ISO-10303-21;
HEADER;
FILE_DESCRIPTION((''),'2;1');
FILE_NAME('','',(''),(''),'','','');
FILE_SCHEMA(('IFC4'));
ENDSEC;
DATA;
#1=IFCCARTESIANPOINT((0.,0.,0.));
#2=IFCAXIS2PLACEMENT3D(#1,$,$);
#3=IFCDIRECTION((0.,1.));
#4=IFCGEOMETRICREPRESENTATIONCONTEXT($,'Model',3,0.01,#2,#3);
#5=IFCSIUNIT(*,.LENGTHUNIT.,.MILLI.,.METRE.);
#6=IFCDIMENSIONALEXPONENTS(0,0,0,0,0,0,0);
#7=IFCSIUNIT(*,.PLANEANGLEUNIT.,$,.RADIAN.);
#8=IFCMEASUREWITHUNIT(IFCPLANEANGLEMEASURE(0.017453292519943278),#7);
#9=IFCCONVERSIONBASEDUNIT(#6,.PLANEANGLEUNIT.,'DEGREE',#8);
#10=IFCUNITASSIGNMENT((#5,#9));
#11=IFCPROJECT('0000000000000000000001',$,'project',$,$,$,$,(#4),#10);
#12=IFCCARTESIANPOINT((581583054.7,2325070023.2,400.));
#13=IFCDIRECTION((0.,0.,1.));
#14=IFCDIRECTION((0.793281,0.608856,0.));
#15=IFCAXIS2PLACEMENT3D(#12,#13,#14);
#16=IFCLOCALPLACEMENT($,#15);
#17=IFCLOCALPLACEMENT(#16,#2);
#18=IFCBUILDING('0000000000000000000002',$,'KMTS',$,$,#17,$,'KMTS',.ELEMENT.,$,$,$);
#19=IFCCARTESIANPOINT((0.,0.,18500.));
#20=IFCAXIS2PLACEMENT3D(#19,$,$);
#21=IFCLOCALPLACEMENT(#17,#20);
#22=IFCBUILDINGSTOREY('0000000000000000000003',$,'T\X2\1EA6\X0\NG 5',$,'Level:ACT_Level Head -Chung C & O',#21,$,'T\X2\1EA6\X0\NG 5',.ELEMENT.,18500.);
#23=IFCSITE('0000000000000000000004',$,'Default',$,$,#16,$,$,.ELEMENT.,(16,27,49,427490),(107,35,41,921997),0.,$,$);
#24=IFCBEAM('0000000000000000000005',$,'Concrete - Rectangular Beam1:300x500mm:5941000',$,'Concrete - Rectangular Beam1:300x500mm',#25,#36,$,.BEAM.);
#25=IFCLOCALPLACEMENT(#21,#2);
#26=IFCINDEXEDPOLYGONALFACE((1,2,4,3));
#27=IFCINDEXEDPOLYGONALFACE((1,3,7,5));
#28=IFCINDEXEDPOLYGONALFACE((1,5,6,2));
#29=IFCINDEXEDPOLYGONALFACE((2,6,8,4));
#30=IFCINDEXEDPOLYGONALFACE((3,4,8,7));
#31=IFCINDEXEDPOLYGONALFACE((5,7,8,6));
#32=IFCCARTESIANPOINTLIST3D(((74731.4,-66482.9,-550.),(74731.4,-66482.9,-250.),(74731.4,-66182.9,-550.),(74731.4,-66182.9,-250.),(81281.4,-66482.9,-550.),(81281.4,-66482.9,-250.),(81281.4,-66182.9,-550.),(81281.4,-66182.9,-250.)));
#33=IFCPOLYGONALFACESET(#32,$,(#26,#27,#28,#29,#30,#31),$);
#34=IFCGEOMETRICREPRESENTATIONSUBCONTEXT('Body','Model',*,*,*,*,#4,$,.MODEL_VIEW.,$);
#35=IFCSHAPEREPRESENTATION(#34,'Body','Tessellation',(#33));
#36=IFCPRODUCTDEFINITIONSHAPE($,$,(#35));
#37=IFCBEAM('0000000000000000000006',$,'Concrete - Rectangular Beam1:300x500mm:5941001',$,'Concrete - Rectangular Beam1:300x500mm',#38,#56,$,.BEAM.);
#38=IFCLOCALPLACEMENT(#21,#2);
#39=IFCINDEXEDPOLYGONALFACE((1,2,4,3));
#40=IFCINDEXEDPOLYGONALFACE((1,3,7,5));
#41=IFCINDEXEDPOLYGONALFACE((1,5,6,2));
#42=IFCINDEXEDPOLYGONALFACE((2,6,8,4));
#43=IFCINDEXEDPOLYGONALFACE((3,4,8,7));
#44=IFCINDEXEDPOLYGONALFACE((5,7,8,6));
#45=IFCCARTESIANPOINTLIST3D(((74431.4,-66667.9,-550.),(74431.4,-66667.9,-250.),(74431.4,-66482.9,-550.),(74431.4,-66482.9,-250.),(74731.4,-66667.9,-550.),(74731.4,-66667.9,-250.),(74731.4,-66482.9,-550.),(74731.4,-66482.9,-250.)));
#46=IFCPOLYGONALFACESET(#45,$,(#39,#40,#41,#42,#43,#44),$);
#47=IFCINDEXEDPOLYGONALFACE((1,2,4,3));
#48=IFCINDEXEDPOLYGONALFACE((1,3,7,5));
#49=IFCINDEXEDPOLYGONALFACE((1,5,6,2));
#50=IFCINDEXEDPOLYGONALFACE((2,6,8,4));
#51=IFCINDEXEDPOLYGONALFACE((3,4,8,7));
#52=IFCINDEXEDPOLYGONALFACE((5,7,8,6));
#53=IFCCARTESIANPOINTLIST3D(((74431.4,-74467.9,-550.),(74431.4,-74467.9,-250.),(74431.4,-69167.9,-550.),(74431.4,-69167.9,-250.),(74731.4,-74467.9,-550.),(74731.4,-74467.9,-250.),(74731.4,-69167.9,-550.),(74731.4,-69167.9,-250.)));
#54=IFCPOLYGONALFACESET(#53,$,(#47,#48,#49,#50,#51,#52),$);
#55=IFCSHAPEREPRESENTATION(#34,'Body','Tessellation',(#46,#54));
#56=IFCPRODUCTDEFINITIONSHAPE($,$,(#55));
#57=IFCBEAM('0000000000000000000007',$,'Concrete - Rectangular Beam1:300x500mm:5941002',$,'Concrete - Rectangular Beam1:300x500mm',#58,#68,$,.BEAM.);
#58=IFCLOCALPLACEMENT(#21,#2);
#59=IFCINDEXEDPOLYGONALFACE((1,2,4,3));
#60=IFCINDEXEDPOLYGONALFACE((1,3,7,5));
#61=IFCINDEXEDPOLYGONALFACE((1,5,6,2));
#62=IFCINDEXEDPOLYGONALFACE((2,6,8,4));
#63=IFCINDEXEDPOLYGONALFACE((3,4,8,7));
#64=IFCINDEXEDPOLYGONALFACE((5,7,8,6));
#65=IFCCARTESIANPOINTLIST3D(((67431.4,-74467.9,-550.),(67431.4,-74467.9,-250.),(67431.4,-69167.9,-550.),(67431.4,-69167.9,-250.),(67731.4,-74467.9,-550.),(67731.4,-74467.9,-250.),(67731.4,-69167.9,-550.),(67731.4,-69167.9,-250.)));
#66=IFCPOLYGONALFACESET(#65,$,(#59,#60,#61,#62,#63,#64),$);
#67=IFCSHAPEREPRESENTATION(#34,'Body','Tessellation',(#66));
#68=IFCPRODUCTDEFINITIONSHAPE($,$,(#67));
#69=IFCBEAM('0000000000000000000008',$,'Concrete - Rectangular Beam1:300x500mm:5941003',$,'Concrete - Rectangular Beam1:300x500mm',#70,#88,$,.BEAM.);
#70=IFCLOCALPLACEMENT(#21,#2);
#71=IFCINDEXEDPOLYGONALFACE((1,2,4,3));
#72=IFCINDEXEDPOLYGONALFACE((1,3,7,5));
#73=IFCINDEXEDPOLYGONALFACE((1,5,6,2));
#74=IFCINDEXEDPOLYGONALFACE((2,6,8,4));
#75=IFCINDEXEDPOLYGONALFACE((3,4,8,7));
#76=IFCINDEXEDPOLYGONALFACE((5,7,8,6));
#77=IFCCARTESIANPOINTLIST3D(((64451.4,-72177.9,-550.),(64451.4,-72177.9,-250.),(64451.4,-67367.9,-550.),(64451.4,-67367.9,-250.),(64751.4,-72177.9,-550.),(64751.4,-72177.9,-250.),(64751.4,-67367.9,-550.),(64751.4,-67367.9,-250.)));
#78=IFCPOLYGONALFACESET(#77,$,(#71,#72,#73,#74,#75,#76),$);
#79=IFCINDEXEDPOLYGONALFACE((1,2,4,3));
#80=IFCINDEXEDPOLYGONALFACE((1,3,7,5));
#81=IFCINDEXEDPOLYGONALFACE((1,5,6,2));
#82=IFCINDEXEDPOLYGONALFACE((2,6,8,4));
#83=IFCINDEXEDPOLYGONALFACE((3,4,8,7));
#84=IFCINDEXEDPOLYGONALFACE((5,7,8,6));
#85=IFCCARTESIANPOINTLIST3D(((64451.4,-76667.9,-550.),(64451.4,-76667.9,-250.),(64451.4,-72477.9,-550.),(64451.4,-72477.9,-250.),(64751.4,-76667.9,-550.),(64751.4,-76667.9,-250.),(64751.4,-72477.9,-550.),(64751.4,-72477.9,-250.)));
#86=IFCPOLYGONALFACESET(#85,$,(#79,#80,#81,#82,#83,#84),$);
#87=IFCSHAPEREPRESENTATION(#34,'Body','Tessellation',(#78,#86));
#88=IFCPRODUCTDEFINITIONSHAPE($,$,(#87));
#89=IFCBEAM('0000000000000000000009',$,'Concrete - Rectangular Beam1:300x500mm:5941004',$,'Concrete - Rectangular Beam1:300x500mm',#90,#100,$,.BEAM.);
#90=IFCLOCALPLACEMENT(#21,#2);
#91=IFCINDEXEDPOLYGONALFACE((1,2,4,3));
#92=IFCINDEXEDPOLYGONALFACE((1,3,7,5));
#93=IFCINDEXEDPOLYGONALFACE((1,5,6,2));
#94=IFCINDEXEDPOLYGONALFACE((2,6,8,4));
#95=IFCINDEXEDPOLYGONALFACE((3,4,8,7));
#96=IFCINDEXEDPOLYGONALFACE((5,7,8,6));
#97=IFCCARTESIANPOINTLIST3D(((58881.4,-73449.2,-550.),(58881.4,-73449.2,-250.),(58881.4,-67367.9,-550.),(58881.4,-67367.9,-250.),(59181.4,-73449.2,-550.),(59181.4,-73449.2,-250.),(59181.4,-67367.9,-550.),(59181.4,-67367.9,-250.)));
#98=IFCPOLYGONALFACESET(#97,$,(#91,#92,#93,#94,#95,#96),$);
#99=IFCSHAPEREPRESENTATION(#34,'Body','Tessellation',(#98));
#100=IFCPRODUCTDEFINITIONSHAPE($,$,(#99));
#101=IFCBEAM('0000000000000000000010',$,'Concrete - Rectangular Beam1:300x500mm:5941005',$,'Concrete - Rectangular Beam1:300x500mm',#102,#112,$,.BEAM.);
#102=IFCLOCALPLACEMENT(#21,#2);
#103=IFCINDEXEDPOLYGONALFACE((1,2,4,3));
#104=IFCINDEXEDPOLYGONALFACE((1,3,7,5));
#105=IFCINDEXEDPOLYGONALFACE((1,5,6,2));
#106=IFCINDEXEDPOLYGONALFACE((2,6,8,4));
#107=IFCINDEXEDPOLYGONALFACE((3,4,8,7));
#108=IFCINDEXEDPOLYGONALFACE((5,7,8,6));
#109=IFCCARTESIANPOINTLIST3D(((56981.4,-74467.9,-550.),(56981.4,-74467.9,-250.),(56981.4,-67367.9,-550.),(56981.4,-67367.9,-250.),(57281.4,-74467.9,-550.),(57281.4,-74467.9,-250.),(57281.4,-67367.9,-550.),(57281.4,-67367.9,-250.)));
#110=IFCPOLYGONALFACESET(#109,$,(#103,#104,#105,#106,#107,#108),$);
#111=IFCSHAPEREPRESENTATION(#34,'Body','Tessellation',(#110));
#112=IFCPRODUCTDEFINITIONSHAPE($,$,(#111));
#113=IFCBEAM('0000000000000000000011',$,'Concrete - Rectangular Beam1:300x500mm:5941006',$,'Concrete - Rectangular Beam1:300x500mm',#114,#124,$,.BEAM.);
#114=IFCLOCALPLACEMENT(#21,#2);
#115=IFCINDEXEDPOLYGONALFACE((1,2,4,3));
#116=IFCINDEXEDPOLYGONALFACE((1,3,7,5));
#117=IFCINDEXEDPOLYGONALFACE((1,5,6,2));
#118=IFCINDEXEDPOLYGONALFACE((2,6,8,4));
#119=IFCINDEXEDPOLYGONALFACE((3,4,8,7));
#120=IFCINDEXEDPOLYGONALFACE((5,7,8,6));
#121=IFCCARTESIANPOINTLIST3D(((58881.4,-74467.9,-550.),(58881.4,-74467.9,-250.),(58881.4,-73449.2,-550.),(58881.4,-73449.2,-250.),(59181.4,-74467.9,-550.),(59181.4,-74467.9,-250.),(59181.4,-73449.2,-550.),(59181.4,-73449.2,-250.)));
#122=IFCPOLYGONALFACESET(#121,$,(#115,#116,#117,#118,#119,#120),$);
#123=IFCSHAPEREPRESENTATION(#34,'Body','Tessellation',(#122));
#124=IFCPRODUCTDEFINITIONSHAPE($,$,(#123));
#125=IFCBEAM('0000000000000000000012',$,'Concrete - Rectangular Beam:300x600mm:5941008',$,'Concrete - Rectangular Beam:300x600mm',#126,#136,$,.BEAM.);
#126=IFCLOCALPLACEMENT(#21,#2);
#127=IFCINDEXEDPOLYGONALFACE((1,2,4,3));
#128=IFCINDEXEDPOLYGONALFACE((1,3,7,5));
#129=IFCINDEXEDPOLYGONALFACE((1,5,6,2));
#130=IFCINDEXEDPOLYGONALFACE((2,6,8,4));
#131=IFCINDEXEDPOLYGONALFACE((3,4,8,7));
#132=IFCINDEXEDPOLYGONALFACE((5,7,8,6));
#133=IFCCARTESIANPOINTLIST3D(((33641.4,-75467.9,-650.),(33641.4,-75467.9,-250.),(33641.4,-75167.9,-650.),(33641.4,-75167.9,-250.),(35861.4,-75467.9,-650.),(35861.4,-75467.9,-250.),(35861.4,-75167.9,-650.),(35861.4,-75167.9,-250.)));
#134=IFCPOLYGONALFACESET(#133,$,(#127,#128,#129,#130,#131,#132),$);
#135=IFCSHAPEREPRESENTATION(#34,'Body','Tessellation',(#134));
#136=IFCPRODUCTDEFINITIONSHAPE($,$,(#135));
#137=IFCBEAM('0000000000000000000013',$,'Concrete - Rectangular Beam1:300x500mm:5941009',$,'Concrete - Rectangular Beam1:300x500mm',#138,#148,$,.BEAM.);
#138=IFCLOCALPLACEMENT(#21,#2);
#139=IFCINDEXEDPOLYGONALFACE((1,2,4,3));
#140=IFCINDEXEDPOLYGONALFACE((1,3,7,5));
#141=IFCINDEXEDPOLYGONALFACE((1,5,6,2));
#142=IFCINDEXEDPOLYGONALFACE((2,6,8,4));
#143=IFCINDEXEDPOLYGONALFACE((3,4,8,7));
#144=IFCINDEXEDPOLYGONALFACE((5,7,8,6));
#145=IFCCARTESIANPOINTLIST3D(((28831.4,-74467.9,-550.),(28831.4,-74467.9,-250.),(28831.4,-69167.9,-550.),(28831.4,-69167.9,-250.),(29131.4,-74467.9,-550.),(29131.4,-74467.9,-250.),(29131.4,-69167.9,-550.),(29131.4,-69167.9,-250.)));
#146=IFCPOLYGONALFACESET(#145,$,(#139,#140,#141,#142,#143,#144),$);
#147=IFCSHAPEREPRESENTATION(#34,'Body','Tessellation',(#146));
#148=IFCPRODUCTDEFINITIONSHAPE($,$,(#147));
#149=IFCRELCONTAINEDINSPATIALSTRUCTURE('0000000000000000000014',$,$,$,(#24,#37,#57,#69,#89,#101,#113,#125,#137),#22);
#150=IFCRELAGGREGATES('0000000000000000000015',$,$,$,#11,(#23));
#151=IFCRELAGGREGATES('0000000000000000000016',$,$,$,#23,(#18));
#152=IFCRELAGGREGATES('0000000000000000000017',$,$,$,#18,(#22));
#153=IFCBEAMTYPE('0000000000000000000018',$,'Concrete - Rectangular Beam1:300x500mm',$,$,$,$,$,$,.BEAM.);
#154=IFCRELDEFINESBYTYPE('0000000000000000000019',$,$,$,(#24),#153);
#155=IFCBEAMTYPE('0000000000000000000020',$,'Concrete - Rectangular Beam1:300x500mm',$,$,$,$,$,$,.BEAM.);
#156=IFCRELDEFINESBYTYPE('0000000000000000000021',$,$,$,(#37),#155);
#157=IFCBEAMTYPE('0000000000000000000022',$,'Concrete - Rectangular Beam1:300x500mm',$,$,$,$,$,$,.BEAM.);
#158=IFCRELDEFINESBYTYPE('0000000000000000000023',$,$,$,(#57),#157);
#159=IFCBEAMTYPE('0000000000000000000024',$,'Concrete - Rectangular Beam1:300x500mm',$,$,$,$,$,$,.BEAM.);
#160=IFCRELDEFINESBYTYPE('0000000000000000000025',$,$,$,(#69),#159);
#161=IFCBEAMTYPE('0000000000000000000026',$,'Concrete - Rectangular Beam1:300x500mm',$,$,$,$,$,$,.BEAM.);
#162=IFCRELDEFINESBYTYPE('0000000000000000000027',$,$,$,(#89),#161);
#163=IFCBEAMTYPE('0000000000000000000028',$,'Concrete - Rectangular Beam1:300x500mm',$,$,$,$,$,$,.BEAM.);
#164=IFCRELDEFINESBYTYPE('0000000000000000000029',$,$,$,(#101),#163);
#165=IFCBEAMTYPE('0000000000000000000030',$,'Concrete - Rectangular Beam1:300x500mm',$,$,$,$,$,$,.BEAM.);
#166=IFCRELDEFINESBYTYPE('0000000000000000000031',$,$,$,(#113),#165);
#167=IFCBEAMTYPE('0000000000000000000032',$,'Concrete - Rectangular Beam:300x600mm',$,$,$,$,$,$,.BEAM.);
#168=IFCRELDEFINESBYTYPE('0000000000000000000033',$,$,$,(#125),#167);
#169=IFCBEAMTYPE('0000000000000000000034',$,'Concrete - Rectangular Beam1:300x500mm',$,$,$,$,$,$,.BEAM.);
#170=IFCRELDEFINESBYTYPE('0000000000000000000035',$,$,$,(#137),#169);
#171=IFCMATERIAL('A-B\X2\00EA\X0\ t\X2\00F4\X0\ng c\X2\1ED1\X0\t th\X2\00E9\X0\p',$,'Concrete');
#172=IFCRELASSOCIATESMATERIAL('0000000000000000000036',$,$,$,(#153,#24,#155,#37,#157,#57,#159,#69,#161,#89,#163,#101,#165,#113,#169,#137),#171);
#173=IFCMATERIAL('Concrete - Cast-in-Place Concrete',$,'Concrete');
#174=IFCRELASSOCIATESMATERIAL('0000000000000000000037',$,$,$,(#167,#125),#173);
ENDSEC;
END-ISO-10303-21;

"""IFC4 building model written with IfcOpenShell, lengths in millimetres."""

from ifc_helpers import new_model, entity, si_unit, converted_unit, direction, frame, origin, place, context, subcontext, project, spatial, indexed_curve, outline, extrude, source, transform, mapped, material, type_object, type_shapes, element, save


model = new_model("IFC4")

# Units and contexts
model_context = context("Model", 3, precision=0.01, world=origin(), true_north=direction((0.0, 1.0)))
body_context = subcontext(model_context, "Body", "Model", "MODEL_VIEW")
ifc_project = project(units=[si_unit("LENGTHUNIT", "METRE", prefix="MILLI"), converted_unit("PLANEANGLEUNIT", "DEGREE", entity("IfcPlaneAngleMeasure", 0.017453292519943278), si_unit("PLANEANGLEUNIT", "RADIAN"), dimensions=[0, 0, 0, 0, 0, 0, 0])], contexts=[model_context])

# Site, building, storey
site_placement = place(None, frame((581583054.7, 2325070023.2, 400.0), z_axis=(0.0, 0.0, 1.0), x_axis=(0.793281, 0.608856, 0.0)))
site = spatial("IfcSite", under=ifc_project, at=site_placement, Name="Default", CompositionType="ELEMENT", RefLatitude=(16, 27, 49, 427490), RefLongitude=(107, 35, 41, 921997), RefElevation=0.0)
building_placement = place(site_placement, origin())
building = spatial("IfcBuilding", under=site, at=building_placement, Name="KMTS", LongName="KMTS", CompositionType="ELEMENT")
storey_placement = place(building_placement, frame((0.0, 0.0, 18500.0)))
storey = spatial("IfcBuildingStorey", under=building, at=storey_placement, Name="TẦNG 5", ObjectType="Level:ACT_Level Head -Chung C & O", LongName="TẦNG 5", CompositionType="ELEMENT", Elevation=18500.0)

# Beams
ifc_material_1 = material(Name="A-Bê tông cốt thép", Category="Concrete")
beam_type_1 = type_object("IfcBeamType", Name="Concrete - Rectangular Beam1:300x500mm", PredefinedType="BEAM", material=ifc_material_1)
shared_shape_1 = source(origin(), body_context, "Body", "SweptSolid", [
    extrude(outline(indexed_curve([(-150.0, -150.0), (150.0, -150.0), (150.0, 150.0), (-150.0, 150.0), (-150.0, -150.0)], self_intersect=False)), frame((81281.4, -66332.9, 18100.0), z_axis=(-1.0, 0.0, 0.0), x_axis=(0.0, 0.0, -1.0)), (0.0, 0.0, 1.0), 6550.0),
])
type_shapes(beam_type_1, [shared_shape_1])
beam_1_placement = place(storey_placement, frame((0.0, 0.0, -18500.0)))
element("IfcBeam", 1, at=beam_1_placement, inside=storey, type_object=beam_type_1, material=ifc_material_1, Name="Concrete - Rectangular Beam1:300x500mm:5941000", ObjectType="Concrete - Rectangular Beam1:300x500mm", PredefinedType="BEAM", context=body_context, shape_type="MappedRepresentation", body=[
    mapped(shared_shape_1, transform((0.0, 0.0, 0.0), scale=1.0)),
])
beam_type_2 = type_object("IfcBeamType", Name="Concrete - Rectangular Beam1:300x500mm", PredefinedType="BEAM", material=ifc_material_1)
shared_shape_2 = source(origin(), body_context, "Body", "SweptSolid", [
    extrude(outline(indexed_curve([(-150.0, -150.0), (150.0, -150.0), (150.0, 150.0), (-150.0, 150.0), (-150.0, -150.0)], self_intersect=False)), frame((74581.4, -66482.9, 18100.0), z_axis=(0.0, -1.0, 0.0), x_axis=(-1.0, 0.0, 0.0)), (0.0, 0.0, 1.0), 185.0),
    extrude(outline(indexed_curve([(-150.0, -150.0), (150.0, -150.0), (150.0, 150.0), (-150.0, 150.0), (-150.0, -150.0)], self_intersect=False)), frame((74581.4, -69167.9, 18100.0), z_axis=(0.0, -1.0, 0.0), x_axis=(-1.0, 0.0, 0.0)), (0.0, 0.0, 1.0), 5300.0),
])
type_shapes(beam_type_2, [shared_shape_2])
beam_2_placement = place(storey_placement, frame((0.0, 0.0, -18500.0)))
element("IfcBeam", 2, at=beam_2_placement, inside=storey, type_object=beam_type_2, material=ifc_material_1, Name="Concrete - Rectangular Beam1:300x500mm:5941001", ObjectType="Concrete - Rectangular Beam1:300x500mm", PredefinedType="BEAM", context=body_context, shape_type="MappedRepresentation", body=[
    mapped(shared_shape_2, transform((0.0, 0.0, 0.0), scale=1.0)),
])
beam_type_3 = type_object("IfcBeamType", Name="Concrete - Rectangular Beam1:300x500mm", PredefinedType="BEAM", material=ifc_material_1)
shared_shape_3 = source(origin(), body_context, "Body", "SweptSolid", [
    extrude(outline(indexed_curve([(-150.0, -150.0), (150.0, -150.0), (150.0, 150.0), (-150.0, 150.0), (-150.0, -150.0)], self_intersect=False)), frame((67581.4, -69167.9, 18100.0), z_axis=(0.0, -1.0, 0.0), x_axis=(-1.0, 0.0, 0.0)), (0.0, 0.0, 1.0), 5300.0),
])
type_shapes(beam_type_3, [shared_shape_3])
beam_3_placement = place(storey_placement, frame((0.0, 0.0, -18500.0)))
element("IfcBeam", 3, at=beam_3_placement, inside=storey, type_object=beam_type_3, material=ifc_material_1, Name="Concrete - Rectangular Beam1:300x500mm:5941002", ObjectType="Concrete - Rectangular Beam1:300x500mm", PredefinedType="BEAM", context=body_context, shape_type="MappedRepresentation", body=[
    mapped(shared_shape_3, transform((0.0, 0.0, 0.0), scale=1.0)),
])
beam_type_4 = type_object("IfcBeamType", Name="Concrete - Rectangular Beam1:300x500mm", PredefinedType="BEAM", material=ifc_material_1)
shared_shape_4 = source(origin(), body_context, "Body", "SweptSolid", [
    extrude(outline(indexed_curve([(-150.0, -150.0), (150.0, -150.0), (150.0, 150.0), (-150.0, 150.0), (-150.0, -150.0)], self_intersect=False)), frame((64601.4, -67367.9, 18100.0), z_axis=(0.0, -1.0, 0.0), x_axis=(-1.0, 0.0, 0.0)), (0.0, 0.0, 1.0), 4810.0),
    extrude(outline(indexed_curve([(-150.0, -150.0), (150.0, -150.0), (150.0, 150.0), (-150.0, 150.0), (-150.0, -150.0)], self_intersect=False)), frame((64601.4, -72477.9, 18100.0), z_axis=(0.0, -1.0, 0.0), x_axis=(-1.0, 0.0, 0.0)), (0.0, 0.0, 1.0), 4190.0),
])
type_shapes(beam_type_4, [shared_shape_4])
beam_4_placement = place(storey_placement, frame((0.0, 0.0, -18500.0)))
element("IfcBeam", 4, at=beam_4_placement, inside=storey, type_object=beam_type_4, material=ifc_material_1, Name="Concrete - Rectangular Beam1:300x500mm:5941003", ObjectType="Concrete - Rectangular Beam1:300x500mm", PredefinedType="BEAM", context=body_context, shape_type="MappedRepresentation", body=[
    mapped(shared_shape_4, transform((0.0, 0.0, 0.0), scale=1.0)),
])
beam_type_5 = type_object("IfcBeamType", Name="Concrete - Rectangular Beam1:300x500mm", PredefinedType="BEAM", material=ifc_material_1)
shared_shape_5 = source(origin(), body_context, "Body", "SweptSolid", [
    extrude(outline(indexed_curve([(-150.0, -150.0), (150.0, -150.0), (150.0, 150.0), (-150.0, 150.0), (-150.0, -150.0)], self_intersect=False)), frame((59031.4, -73449.2, 18100.0), z_axis=(0.0, 1.0, 0.0), x_axis=(-1.0, 0.0, 0.0)), (0.0, 0.0, 1.0), 6081.3),
])
type_shapes(beam_type_5, [shared_shape_5])
beam_5_placement = place(storey_placement, frame((0.0, 0.0, -18500.0)))
element("IfcBeam", 5, at=beam_5_placement, inside=storey, type_object=beam_type_5, material=ifc_material_1, Name="Concrete - Rectangular Beam1:300x500mm:5941004", ObjectType="Concrete - Rectangular Beam1:300x500mm", PredefinedType="BEAM", context=body_context, shape_type="MappedRepresentation", body=[
    mapped(shared_shape_5, transform((0.0, 0.0, 0.0), scale=1.0)),
])
beam_type_6 = type_object("IfcBeamType", Name="Concrete - Rectangular Beam1:300x500mm", PredefinedType="BEAM", material=ifc_material_1)
shared_shape_6 = source(origin(), body_context, "Body", "SweptSolid", [
    extrude(outline(indexed_curve([(-150.0, -150.0), (150.0, -150.0), (150.0, 150.0), (-150.0, 150.0), (-150.0, -150.0)], self_intersect=False)), frame((57131.4, -67367.9, 18100.0), z_axis=(0.0, -1.0, 0.0), x_axis=(-1.0, 0.0, 0.0)), (0.0, 0.0, 1.0), 7100.0),
])
type_shapes(beam_type_6, [shared_shape_6])
beam_6_placement = place(storey_placement, frame((0.0, 0.0, -18500.0)))
element("IfcBeam", 6, at=beam_6_placement, inside=storey, type_object=beam_type_6, material=ifc_material_1, Name="Concrete - Rectangular Beam1:300x500mm:5941005", ObjectType="Concrete - Rectangular Beam1:300x500mm", PredefinedType="BEAM", context=body_context, shape_type="MappedRepresentation", body=[
    mapped(shared_shape_6, transform((0.0, 0.0, 0.0), scale=1.0)),
])
beam_type_7 = type_object("IfcBeamType", Name="Concrete - Rectangular Beam1:300x500mm", PredefinedType="BEAM", material=ifc_material_1)
shared_shape_7 = source(origin(), body_context, "Body", "SweptSolid", [
    extrude(outline(indexed_curve([(-150.0, -150.0), (150.0, -150.0), (150.0, 150.0), (-150.0, 150.0), (-150.0, -150.0)], self_intersect=False)), frame((59031.4, -74467.9, 18100.0), z_axis=(0.0, 1.0, 0.0), x_axis=(-1.0, 0.0, 0.0)), (0.0, 0.0, 1.0), 1018.7),
])
type_shapes(beam_type_7, [shared_shape_7])
beam_7_placement = place(storey_placement, frame((0.0, 0.0, -18500.0)))
element("IfcBeam", 7, at=beam_7_placement, inside=storey, type_object=beam_type_7, material=ifc_material_1, Name="Concrete - Rectangular Beam1:300x500mm:5941006", ObjectType="Concrete - Rectangular Beam1:300x500mm", PredefinedType="BEAM", context=body_context, shape_type="MappedRepresentation", body=[
    mapped(shared_shape_7, transform((0.0, 0.0, 0.0), scale=1.0)),
])
ifc_material_2 = material(Name="Concrete - Cast-in-Place Concrete", Category="Concrete")
beam_type_8 = type_object("IfcBeamType", Name="Concrete - Rectangular Beam:300x600mm", PredefinedType="BEAM", material=ifc_material_2)
shared_shape_8 = source(origin(), body_context, "Body", "SweptSolid", [
    extrude(outline(indexed_curve([(-200.0, -150.0), (200.0, -150.0), (200.0, 150.0), (-200.0, 150.0), (-200.0, -150.0)], self_intersect=False)), frame((33641.4, -75317.9, 18050.0), z_axis=(1.0, 0.0, 0.0), x_axis=(0.0, 0.0, -1.0)), (0.0, 0.0, 1.0), 2220.0),
])
type_shapes(beam_type_8, [shared_shape_8])
beam_8_placement = place(storey_placement, frame((0.0, 0.0, -18500.0)))
element("IfcBeam", 8, at=beam_8_placement, inside=storey, type_object=beam_type_8, material=ifc_material_2, Name="Concrete - Rectangular Beam:300x600mm:5941008", ObjectType="Concrete - Rectangular Beam:300x600mm", PredefinedType="BEAM", context=body_context, shape_type="MappedRepresentation", body=[
    mapped(shared_shape_8, transform((0.0, 0.0, 0.0), scale=1.0)),
])
beam_type_9 = type_object("IfcBeamType", Name="Concrete - Rectangular Beam1:300x500mm", PredefinedType="BEAM", material=ifc_material_1)
shared_shape_9 = source(origin(), body_context, "Body", "SweptSolid", [
    extrude(outline(indexed_curve([(-150.0, -150.0), (150.0, -150.0), (150.0, 150.0), (-150.0, 150.0), (-150.0, -150.0)], self_intersect=False)), frame((28981.4, -69167.9, 18100.0), z_axis=(0.0, -1.0, 0.0), x_axis=(-1.0, 0.0, 0.0)), (0.0, 0.0, 1.0), 5300.0),
])
type_shapes(beam_type_9, [shared_shape_9])
beam_9_placement = place(storey_placement, frame((0.0, 0.0, -18500.0)))
element("IfcBeam", 9, at=beam_9_placement, inside=storey, type_object=beam_type_9, material=ifc_material_1, Name="Concrete - Rectangular Beam1:300x500mm:5941009", ObjectType="Concrete - Rectangular Beam1:300x500mm", PredefinedType="BEAM", context=body_context, shape_type="MappedRepresentation", body=[
    mapped(shared_shape_9, transform((0.0, 0.0, 0.0), scale=1.0)),
])

save(model, "model.ifc")
